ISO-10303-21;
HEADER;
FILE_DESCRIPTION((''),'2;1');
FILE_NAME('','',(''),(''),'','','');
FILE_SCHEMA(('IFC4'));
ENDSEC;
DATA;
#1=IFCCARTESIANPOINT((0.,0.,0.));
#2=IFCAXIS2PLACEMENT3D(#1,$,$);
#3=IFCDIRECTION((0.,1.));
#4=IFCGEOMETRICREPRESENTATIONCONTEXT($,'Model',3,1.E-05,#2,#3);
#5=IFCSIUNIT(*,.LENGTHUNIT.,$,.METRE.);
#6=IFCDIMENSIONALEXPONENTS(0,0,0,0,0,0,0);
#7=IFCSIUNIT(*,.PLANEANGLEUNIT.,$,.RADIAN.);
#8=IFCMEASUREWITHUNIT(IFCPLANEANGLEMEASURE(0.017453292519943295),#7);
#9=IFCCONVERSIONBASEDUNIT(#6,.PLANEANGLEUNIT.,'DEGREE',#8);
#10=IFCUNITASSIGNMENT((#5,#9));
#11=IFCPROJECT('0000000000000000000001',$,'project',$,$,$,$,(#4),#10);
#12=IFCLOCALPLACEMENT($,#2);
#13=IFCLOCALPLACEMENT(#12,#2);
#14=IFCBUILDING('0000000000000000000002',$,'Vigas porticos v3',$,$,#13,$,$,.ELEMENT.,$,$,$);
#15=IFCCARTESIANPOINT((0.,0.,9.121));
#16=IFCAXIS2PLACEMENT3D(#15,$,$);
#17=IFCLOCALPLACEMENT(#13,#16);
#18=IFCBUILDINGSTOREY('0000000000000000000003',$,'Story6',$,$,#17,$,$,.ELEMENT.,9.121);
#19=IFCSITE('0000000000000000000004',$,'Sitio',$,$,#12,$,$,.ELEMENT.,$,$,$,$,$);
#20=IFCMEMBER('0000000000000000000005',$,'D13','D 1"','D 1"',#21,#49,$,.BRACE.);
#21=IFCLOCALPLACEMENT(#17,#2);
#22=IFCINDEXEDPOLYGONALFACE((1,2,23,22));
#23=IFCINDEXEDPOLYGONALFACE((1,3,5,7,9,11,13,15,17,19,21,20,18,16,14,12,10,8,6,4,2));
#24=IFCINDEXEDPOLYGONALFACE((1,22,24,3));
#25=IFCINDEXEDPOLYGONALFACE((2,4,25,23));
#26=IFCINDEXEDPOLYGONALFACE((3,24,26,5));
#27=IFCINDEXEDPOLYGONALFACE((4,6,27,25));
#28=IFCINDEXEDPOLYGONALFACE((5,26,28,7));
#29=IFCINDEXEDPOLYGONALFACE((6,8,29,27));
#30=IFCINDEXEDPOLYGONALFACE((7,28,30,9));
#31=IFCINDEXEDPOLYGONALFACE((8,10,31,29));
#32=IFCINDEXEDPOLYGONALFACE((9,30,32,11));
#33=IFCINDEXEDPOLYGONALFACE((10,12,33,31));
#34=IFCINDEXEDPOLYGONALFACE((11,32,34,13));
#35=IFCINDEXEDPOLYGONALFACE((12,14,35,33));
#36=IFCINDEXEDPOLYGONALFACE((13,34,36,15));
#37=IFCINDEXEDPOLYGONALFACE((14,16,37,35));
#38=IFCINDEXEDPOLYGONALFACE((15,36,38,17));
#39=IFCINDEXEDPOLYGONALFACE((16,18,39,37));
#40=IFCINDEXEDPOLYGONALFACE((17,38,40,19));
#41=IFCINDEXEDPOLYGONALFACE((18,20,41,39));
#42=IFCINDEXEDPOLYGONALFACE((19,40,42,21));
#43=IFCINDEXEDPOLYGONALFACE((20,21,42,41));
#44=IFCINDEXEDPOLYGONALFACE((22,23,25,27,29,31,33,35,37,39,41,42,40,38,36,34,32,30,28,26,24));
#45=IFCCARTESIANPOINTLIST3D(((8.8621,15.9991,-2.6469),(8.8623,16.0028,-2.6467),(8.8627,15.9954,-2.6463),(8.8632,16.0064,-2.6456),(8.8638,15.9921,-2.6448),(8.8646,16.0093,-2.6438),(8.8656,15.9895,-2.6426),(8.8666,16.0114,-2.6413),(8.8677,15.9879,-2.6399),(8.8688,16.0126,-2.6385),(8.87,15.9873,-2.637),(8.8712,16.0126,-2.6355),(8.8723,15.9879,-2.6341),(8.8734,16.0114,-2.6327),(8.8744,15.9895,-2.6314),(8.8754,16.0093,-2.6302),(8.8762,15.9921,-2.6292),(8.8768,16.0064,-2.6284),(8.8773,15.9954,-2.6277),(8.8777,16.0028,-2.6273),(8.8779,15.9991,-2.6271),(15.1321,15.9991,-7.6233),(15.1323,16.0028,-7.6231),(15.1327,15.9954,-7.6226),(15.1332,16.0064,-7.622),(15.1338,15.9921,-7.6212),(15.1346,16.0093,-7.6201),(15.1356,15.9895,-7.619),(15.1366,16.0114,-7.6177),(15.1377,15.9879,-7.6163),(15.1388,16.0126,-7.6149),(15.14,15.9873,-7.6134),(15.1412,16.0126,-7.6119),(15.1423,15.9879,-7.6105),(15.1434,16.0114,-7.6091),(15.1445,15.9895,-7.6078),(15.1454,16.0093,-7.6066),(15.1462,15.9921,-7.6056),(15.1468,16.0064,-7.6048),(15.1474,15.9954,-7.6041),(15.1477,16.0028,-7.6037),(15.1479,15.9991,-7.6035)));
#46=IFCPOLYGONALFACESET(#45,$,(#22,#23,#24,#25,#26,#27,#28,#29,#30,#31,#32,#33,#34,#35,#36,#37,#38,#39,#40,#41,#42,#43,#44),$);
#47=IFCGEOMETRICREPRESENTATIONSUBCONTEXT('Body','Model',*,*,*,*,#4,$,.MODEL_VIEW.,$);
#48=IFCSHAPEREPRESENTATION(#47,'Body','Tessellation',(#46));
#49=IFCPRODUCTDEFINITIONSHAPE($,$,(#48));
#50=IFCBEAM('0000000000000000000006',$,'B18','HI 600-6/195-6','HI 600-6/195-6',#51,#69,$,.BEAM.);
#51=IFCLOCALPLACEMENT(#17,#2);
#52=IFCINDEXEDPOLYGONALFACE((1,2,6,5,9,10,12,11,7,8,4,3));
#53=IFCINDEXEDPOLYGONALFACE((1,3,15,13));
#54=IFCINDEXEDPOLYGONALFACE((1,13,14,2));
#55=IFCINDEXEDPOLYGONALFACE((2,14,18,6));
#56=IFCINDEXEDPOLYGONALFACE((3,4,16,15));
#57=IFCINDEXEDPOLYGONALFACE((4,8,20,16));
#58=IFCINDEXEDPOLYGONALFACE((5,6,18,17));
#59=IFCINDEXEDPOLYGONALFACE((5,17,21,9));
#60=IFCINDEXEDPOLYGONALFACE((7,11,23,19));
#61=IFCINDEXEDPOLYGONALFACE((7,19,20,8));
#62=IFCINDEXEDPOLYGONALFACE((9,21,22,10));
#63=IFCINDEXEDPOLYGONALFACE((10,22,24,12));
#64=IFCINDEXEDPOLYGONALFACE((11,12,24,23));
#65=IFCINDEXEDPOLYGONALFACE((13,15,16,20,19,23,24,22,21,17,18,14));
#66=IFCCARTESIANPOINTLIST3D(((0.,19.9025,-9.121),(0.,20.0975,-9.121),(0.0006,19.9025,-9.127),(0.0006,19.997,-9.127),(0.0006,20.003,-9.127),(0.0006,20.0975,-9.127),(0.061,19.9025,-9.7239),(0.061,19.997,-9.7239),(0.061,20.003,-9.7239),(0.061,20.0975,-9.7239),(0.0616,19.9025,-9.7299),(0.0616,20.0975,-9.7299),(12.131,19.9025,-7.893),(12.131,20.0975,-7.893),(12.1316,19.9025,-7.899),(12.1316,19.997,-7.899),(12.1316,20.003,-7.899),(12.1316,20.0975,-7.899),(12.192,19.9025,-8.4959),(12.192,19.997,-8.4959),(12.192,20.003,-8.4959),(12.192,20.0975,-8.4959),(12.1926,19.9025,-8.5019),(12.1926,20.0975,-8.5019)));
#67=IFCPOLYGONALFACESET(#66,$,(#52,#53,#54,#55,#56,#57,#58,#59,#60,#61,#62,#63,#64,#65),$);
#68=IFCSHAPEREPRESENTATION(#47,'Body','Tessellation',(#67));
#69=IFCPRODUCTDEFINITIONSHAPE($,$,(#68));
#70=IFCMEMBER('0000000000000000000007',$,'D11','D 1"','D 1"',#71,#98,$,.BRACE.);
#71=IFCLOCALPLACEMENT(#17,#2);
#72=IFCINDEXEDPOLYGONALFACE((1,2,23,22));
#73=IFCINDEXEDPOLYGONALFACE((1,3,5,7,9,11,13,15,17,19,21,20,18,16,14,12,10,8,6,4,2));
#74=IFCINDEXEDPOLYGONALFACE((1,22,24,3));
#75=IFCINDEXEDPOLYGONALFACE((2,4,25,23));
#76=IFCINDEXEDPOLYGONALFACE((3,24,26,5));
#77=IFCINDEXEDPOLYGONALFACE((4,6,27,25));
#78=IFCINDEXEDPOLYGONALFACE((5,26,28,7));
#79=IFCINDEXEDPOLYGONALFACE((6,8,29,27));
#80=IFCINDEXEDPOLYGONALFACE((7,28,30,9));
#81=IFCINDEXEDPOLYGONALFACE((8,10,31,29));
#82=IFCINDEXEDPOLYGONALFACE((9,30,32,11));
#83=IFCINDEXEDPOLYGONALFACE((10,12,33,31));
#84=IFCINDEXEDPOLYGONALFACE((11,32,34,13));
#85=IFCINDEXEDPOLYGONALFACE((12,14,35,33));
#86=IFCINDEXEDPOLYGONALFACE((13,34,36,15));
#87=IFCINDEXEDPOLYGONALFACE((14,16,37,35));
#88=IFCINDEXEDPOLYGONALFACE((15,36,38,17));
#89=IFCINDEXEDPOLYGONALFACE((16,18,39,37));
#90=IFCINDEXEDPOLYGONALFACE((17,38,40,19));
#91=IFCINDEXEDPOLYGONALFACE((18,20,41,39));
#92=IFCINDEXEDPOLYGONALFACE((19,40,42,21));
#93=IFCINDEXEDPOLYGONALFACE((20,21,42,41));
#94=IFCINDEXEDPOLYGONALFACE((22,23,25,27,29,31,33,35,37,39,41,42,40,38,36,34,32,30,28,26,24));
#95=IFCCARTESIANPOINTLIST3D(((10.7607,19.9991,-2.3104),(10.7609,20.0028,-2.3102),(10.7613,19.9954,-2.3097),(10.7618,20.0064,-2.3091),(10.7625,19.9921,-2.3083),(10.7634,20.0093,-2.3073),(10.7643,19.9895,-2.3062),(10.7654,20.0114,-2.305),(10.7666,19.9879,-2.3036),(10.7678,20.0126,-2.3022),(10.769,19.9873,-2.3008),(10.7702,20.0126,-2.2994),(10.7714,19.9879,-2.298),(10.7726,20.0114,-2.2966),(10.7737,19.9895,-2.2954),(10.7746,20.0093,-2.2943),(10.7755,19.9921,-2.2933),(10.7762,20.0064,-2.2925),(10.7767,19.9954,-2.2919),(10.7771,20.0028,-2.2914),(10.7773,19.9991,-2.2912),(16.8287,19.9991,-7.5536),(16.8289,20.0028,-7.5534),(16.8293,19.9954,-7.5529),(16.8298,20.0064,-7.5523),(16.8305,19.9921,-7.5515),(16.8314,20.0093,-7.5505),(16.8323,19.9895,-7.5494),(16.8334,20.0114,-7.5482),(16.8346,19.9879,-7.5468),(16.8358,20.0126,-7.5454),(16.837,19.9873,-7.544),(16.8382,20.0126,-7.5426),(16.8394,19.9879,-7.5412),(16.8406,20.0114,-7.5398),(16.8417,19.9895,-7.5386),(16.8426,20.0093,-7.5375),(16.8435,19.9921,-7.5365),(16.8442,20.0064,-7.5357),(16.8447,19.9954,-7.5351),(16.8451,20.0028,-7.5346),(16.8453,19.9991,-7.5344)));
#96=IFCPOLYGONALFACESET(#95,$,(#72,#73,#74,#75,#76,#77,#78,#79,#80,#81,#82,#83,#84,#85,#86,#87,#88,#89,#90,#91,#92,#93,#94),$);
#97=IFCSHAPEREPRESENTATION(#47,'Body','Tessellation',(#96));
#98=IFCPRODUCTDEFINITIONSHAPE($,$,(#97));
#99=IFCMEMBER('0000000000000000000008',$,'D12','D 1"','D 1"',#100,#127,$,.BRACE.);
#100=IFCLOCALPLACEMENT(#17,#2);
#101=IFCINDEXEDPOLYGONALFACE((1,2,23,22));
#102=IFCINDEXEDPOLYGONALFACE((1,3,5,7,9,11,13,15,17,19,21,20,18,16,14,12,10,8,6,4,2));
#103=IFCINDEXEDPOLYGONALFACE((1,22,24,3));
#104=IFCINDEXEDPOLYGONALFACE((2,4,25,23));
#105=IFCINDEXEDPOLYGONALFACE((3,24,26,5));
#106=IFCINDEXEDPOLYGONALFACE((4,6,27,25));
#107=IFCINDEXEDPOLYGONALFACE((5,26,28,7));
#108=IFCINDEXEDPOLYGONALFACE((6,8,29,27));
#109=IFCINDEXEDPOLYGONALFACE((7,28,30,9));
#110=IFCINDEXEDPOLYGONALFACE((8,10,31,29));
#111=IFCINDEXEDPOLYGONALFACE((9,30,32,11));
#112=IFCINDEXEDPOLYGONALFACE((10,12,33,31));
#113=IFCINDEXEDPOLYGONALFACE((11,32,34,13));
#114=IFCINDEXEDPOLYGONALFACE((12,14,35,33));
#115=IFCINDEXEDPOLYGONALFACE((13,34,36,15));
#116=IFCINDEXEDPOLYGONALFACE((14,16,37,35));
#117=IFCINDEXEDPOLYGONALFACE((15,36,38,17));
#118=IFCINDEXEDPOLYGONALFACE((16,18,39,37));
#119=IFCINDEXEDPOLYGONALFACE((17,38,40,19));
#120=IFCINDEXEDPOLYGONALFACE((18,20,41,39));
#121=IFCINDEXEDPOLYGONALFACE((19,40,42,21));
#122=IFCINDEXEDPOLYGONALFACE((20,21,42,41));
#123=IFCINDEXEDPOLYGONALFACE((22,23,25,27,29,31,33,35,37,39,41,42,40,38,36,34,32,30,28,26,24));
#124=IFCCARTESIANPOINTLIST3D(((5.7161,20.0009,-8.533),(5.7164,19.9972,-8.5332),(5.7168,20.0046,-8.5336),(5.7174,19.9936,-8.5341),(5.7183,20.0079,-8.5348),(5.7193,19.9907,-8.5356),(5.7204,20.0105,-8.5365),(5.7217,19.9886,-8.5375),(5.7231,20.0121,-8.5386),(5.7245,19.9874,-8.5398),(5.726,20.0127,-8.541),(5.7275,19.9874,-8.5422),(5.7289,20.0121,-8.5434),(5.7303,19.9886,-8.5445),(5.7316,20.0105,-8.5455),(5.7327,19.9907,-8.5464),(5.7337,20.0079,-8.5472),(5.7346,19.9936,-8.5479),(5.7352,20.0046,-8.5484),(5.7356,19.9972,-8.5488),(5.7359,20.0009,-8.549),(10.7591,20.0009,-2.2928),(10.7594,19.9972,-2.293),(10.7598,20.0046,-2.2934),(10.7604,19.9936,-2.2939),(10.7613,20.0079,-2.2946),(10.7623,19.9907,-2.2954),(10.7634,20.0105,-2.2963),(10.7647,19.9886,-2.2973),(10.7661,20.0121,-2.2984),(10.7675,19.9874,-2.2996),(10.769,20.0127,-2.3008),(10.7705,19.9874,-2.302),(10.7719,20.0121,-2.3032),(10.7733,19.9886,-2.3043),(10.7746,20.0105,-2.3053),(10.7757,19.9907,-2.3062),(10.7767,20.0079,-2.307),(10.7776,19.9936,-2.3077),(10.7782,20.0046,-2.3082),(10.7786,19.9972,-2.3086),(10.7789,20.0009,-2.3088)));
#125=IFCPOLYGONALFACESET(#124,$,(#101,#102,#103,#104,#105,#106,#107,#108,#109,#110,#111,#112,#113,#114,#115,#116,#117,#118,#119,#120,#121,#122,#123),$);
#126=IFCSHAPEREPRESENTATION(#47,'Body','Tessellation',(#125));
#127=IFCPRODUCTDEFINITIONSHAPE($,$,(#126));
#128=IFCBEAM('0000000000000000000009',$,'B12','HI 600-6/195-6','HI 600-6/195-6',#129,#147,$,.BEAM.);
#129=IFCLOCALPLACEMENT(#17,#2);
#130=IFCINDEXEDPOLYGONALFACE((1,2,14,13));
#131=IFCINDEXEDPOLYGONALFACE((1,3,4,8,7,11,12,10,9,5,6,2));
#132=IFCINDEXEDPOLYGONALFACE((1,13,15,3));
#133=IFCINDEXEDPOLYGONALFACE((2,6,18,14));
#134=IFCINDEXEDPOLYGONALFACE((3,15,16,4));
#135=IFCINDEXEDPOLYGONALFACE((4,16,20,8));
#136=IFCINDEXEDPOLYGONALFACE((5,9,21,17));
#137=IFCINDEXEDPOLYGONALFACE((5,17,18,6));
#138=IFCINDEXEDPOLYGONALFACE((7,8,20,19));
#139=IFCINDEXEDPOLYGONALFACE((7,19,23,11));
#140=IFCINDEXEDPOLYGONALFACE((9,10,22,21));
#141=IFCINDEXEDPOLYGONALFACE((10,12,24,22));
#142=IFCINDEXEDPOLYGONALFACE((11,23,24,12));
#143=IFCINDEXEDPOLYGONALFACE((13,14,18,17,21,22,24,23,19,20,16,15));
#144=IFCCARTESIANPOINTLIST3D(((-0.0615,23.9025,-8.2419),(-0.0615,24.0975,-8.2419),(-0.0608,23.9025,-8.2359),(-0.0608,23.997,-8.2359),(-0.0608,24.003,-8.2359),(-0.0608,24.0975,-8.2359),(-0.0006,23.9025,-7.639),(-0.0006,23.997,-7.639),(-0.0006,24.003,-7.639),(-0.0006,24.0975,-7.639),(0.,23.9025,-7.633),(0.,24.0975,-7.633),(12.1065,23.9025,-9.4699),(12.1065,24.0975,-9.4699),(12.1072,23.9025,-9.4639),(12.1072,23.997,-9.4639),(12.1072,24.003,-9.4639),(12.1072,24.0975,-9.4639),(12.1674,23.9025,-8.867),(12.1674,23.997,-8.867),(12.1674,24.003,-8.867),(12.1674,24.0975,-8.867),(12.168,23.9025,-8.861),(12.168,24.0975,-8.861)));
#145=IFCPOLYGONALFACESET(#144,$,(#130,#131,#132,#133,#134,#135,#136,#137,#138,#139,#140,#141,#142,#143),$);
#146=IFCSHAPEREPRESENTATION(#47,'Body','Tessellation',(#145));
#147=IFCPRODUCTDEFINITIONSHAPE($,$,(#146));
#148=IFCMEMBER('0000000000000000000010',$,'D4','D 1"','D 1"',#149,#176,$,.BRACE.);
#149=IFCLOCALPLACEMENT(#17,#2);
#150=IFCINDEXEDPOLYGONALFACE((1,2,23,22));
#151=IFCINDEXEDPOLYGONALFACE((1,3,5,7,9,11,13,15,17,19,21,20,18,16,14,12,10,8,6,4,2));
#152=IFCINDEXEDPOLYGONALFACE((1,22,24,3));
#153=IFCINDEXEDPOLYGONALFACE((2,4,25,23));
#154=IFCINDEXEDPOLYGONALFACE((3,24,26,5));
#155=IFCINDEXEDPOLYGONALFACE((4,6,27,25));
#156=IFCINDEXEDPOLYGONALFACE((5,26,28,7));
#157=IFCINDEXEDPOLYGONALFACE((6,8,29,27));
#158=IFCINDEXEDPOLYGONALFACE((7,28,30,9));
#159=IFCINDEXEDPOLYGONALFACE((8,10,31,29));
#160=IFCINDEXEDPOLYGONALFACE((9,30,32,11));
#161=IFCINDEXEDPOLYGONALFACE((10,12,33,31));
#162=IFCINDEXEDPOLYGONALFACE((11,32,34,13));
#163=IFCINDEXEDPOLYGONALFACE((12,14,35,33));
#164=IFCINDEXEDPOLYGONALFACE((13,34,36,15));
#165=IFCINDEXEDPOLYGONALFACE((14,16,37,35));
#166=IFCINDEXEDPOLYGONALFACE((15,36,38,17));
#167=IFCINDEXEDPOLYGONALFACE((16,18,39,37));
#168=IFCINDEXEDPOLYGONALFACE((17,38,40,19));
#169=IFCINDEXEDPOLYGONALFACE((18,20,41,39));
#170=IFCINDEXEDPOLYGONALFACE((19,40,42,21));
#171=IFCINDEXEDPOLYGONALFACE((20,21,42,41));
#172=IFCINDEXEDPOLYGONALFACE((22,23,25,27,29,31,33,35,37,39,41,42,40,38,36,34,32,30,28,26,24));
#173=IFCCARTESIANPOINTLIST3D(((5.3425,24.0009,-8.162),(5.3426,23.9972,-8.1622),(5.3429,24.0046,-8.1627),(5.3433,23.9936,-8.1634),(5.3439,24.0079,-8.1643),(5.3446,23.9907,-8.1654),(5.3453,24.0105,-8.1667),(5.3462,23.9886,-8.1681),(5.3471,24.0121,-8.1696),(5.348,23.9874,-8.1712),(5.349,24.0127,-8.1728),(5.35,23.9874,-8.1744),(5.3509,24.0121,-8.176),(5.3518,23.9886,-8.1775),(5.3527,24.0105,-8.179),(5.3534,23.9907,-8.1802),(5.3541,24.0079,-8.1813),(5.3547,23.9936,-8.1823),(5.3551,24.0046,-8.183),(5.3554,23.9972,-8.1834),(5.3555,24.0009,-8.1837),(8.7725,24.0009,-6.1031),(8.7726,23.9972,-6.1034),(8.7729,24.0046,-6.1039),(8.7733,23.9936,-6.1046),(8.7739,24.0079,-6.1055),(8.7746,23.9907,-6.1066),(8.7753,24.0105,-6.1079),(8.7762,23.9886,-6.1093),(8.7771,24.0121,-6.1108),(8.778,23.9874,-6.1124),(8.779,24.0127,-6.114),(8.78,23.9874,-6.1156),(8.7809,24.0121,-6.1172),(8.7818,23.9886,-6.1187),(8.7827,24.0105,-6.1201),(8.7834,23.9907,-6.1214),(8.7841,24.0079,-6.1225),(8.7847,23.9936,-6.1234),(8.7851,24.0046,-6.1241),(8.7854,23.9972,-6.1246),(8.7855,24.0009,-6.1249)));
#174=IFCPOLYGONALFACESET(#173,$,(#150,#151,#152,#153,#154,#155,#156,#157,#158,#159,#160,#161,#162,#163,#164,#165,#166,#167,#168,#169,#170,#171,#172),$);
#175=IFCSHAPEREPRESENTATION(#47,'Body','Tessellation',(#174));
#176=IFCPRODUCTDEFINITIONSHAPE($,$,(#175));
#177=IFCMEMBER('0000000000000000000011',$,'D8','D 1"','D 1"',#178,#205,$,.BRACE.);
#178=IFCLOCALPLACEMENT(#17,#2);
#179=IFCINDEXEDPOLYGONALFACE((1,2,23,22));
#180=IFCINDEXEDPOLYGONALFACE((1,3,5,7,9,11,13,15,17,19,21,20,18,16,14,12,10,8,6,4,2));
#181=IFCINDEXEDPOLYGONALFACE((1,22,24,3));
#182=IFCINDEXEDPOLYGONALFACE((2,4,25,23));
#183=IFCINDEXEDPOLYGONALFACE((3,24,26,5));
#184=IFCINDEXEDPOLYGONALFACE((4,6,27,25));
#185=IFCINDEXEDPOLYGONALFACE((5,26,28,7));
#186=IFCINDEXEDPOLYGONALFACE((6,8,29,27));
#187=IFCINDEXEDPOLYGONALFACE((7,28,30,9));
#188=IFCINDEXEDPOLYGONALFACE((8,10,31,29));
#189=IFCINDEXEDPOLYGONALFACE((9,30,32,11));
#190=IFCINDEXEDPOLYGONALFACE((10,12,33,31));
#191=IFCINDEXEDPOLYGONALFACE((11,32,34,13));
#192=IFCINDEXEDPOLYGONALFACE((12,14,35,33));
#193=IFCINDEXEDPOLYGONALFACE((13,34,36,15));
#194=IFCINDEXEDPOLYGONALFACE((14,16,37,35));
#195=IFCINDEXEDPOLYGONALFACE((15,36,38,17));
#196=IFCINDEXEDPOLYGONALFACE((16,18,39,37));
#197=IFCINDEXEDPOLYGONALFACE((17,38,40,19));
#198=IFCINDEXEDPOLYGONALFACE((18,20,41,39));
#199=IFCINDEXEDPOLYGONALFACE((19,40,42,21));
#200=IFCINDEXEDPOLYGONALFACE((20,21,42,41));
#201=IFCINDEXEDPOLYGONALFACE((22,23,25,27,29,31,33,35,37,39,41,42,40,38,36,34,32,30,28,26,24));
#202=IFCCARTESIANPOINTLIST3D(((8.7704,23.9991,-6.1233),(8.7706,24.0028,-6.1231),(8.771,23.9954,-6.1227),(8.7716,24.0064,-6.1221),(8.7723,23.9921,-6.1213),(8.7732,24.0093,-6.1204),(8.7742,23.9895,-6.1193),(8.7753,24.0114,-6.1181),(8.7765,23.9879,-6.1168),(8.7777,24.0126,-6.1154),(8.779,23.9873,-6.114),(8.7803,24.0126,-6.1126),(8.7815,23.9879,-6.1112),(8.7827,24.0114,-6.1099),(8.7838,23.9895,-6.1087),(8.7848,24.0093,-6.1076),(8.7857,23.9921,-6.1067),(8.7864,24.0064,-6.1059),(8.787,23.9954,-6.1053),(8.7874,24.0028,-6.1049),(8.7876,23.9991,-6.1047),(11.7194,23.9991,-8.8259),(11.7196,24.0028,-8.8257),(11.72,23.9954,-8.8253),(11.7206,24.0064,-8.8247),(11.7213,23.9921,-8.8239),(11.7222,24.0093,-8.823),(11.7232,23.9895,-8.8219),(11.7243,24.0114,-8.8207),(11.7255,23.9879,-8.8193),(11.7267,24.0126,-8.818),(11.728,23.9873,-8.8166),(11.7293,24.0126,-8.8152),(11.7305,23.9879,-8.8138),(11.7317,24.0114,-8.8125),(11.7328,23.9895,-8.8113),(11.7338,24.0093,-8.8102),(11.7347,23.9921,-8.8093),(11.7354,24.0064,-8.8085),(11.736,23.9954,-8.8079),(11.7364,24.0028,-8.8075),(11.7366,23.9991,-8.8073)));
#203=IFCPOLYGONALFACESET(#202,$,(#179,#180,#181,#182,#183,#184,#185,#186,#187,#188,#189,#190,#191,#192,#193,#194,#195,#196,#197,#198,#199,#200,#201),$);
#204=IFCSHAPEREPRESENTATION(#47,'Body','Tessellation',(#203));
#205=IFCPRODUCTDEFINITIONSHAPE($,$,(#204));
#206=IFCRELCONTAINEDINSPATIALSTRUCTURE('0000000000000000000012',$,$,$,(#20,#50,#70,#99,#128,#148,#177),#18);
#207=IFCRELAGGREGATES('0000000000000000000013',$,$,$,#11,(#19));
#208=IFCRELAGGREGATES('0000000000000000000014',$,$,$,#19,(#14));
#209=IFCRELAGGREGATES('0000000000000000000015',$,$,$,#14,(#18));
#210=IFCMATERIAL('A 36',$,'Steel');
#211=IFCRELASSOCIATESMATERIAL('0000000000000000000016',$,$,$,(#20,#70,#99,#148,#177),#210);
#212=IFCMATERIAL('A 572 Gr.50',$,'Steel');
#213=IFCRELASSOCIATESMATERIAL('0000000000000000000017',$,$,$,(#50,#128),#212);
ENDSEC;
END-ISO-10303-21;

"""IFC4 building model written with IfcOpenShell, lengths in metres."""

from ifc_helpers import new_model, entity, si_unit, converted_unit, direction, frame, origin, place, context, subcontext, project, spatial, circle, i_section, extrude, material, element, save


model = new_model("IFC4")

# Units and contexts
model_context = context("Model", 3, precision=1e-05, world=origin(), true_north=direction((0.0, 1.0)))
body_context = subcontext(model_context, "Body", "Model", "MODEL_VIEW")
ifc_project = project(units=[si_unit("LENGTHUNIT", "METRE"), converted_unit("PLANEANGLEUNIT", "DEGREE", entity("IfcPlaneAngleMeasure", 0.017453292519943295), si_unit("PLANEANGLEUNIT", "RADIAN"), dimensions=[0, 0, 0, 0, 0, 0, 0])], contexts=[model_context])

# Site, building, storey
site_placement = place(None, origin())
site = spatial("IfcSite", under=ifc_project, at=site_placement, Name="Sitio", CompositionType="ELEMENT")
building_placement = place(site_placement, origin())
building = spatial("IfcBuilding", under=site, at=building_placement, Name="Vigas porticos v3", CompositionType="ELEMENT")
storey_placement = place(building_placement, frame((0.0, 0.0, 9.121)))
storey = spatial("IfcBuildingStorey", under=building, at=storey_placement, Name="Story6", CompositionType="ELEMENT", Elevation=9.121)

# Shared definitions
ifc_material_1 = material(Name="A 572 Gr.50", Category="Steel")

# Shared definitions
ifc_material_2 = material(Name="A 36", Category="Steel")

# Member
member_1_placement = place(storey_placement, frame((15.14, 16.0, -7.6134), z_axis=(-0.783278, 0.0, 0.621672), x_axis=(0.0, -1.0, 0.0)))
element("IfcMember", 1, at=member_1_placement, inside=storey, material=ifc_material_2, Name="D13", Description="D 1\"", ObjectType="D 1\"", PredefinedType="BRACE", context=body_context, shape_type="SweptSolid", body=[
    extrude(circle(Radius=0.0127), origin(), (0.0, 0.0, 1.0), 8.0048),
])

# Beam
beam_1_placement = place(storey_placement, frame((0.0, 20.0, -9.121), z_axis=(0.994915, 0.0, 0.100714), x_axis=(0.0, 1.0, 0.0)))
element("IfcBeam", 2, at=beam_1_placement, inside=storey, material=ifc_material_1, Name="B18", Description="HI 600-6/195-6", ObjectType="HI 600-6/195-6", PredefinedType="BEAM", context=body_context, shape_type="SweptSolid", body=[
    extrude(i_section(OverallWidth=0.195, OverallDepth=0.612, WebThickness=0.006, FlangeThickness=0.006), frame((0.0, -0.306, 0.0)), (0.0, 0.0, 1.0), 12.193),
])

# Members
member_2_placement = place(storey_placement, frame((16.837, 20.0, -7.544), z_axis=(-0.756659, 0.0, 0.653809), x_axis=(0.0, -1.0, 0.0)))
element("IfcMember", 3, at=member_2_placement, inside=storey, material=ifc_material_2, Name="D11", Description="D 1\"", ObjectType="D 1\"", PredefinedType="BRACE", context=body_context, shape_type="SweptSolid", body=[
    extrude(circle(Radius=0.0127), origin(), (0.0, 0.0, 1.0), 8.0195),
])
member_3_placement = place(storey_placement, frame((5.726, 20.0, -8.541), z_axis=(0.628551, 0.0, 0.777768), x_axis=(0.0, 1.0, 0.0)))
element("IfcMember", 4, at=member_3_placement, inside=storey, material=ifc_material_2, Name="D12", Description="D 1\"", ObjectType="D 1\"", PredefinedType="BRACE", context=body_context, shape_type="SweptSolid", body=[
    extrude(circle(Radius=0.0127), origin(), (0.0, 0.0, 1.0), 8.0232),
])

# Beam
beam_2_placement = place(storey_placement, frame((12.168, 24.0, -8.861), z_axis=(-0.994946, 0.0, 0.10041), x_axis=(0.0, -1.0, 0.0)))
element("IfcBeam", 5, at=beam_2_placement, inside=storey, material=ifc_material_1, Name="B12", Description="HI 600-6/195-6", ObjectType="HI 600-6/195-6", PredefinedType="BEAM", context=body_context, shape_type="SweptSolid", body=[
    extrude(i_section(OverallWidth=0.195, OverallDepth=0.612, WebThickness=0.006, FlangeThickness=0.006), frame((0.0, -0.306, 0.0)), (0.0, 0.0, 1.0), 12.2298),
])

# Members
member_4_placement = place(storey_placement, frame((5.349, 24.0, -8.1728), z_axis=(0.857402, 0.0, 0.514647), x_axis=(0.0, 1.0, 0.0)))
element("IfcMember", 6, at=member_4_placement, inside=storey, material=ifc_material_2, Name="D4", Description="D 1\"", ObjectType="D 1\"", PredefinedType="BRACE", context=body_context, shape_type="SweptSolid", body=[
    extrude(circle(Radius=0.0127), origin(), (0.0, 0.0, 1.0), 4.0005),
])
member_5_placement = place(storey_placement, frame((11.728, 24.0, -8.8166), z_axis=(-0.737236, 0.0, 0.675635), x_axis=(0.0, -1.0, 0.0)))
element("IfcMember", 7, at=member_5_placement, inside=storey, material=ifc_material_2, Name="D8", Description="D 1\"", ObjectType="D 1\"", PredefinedType="BRACE", context=body_context, shape_type="SweptSolid", body=[
    extrude(circle(Radius=0.0127), origin(), (0.0, 0.0, 1.0), 4.0001),
])

save(model, "model.ifc")
